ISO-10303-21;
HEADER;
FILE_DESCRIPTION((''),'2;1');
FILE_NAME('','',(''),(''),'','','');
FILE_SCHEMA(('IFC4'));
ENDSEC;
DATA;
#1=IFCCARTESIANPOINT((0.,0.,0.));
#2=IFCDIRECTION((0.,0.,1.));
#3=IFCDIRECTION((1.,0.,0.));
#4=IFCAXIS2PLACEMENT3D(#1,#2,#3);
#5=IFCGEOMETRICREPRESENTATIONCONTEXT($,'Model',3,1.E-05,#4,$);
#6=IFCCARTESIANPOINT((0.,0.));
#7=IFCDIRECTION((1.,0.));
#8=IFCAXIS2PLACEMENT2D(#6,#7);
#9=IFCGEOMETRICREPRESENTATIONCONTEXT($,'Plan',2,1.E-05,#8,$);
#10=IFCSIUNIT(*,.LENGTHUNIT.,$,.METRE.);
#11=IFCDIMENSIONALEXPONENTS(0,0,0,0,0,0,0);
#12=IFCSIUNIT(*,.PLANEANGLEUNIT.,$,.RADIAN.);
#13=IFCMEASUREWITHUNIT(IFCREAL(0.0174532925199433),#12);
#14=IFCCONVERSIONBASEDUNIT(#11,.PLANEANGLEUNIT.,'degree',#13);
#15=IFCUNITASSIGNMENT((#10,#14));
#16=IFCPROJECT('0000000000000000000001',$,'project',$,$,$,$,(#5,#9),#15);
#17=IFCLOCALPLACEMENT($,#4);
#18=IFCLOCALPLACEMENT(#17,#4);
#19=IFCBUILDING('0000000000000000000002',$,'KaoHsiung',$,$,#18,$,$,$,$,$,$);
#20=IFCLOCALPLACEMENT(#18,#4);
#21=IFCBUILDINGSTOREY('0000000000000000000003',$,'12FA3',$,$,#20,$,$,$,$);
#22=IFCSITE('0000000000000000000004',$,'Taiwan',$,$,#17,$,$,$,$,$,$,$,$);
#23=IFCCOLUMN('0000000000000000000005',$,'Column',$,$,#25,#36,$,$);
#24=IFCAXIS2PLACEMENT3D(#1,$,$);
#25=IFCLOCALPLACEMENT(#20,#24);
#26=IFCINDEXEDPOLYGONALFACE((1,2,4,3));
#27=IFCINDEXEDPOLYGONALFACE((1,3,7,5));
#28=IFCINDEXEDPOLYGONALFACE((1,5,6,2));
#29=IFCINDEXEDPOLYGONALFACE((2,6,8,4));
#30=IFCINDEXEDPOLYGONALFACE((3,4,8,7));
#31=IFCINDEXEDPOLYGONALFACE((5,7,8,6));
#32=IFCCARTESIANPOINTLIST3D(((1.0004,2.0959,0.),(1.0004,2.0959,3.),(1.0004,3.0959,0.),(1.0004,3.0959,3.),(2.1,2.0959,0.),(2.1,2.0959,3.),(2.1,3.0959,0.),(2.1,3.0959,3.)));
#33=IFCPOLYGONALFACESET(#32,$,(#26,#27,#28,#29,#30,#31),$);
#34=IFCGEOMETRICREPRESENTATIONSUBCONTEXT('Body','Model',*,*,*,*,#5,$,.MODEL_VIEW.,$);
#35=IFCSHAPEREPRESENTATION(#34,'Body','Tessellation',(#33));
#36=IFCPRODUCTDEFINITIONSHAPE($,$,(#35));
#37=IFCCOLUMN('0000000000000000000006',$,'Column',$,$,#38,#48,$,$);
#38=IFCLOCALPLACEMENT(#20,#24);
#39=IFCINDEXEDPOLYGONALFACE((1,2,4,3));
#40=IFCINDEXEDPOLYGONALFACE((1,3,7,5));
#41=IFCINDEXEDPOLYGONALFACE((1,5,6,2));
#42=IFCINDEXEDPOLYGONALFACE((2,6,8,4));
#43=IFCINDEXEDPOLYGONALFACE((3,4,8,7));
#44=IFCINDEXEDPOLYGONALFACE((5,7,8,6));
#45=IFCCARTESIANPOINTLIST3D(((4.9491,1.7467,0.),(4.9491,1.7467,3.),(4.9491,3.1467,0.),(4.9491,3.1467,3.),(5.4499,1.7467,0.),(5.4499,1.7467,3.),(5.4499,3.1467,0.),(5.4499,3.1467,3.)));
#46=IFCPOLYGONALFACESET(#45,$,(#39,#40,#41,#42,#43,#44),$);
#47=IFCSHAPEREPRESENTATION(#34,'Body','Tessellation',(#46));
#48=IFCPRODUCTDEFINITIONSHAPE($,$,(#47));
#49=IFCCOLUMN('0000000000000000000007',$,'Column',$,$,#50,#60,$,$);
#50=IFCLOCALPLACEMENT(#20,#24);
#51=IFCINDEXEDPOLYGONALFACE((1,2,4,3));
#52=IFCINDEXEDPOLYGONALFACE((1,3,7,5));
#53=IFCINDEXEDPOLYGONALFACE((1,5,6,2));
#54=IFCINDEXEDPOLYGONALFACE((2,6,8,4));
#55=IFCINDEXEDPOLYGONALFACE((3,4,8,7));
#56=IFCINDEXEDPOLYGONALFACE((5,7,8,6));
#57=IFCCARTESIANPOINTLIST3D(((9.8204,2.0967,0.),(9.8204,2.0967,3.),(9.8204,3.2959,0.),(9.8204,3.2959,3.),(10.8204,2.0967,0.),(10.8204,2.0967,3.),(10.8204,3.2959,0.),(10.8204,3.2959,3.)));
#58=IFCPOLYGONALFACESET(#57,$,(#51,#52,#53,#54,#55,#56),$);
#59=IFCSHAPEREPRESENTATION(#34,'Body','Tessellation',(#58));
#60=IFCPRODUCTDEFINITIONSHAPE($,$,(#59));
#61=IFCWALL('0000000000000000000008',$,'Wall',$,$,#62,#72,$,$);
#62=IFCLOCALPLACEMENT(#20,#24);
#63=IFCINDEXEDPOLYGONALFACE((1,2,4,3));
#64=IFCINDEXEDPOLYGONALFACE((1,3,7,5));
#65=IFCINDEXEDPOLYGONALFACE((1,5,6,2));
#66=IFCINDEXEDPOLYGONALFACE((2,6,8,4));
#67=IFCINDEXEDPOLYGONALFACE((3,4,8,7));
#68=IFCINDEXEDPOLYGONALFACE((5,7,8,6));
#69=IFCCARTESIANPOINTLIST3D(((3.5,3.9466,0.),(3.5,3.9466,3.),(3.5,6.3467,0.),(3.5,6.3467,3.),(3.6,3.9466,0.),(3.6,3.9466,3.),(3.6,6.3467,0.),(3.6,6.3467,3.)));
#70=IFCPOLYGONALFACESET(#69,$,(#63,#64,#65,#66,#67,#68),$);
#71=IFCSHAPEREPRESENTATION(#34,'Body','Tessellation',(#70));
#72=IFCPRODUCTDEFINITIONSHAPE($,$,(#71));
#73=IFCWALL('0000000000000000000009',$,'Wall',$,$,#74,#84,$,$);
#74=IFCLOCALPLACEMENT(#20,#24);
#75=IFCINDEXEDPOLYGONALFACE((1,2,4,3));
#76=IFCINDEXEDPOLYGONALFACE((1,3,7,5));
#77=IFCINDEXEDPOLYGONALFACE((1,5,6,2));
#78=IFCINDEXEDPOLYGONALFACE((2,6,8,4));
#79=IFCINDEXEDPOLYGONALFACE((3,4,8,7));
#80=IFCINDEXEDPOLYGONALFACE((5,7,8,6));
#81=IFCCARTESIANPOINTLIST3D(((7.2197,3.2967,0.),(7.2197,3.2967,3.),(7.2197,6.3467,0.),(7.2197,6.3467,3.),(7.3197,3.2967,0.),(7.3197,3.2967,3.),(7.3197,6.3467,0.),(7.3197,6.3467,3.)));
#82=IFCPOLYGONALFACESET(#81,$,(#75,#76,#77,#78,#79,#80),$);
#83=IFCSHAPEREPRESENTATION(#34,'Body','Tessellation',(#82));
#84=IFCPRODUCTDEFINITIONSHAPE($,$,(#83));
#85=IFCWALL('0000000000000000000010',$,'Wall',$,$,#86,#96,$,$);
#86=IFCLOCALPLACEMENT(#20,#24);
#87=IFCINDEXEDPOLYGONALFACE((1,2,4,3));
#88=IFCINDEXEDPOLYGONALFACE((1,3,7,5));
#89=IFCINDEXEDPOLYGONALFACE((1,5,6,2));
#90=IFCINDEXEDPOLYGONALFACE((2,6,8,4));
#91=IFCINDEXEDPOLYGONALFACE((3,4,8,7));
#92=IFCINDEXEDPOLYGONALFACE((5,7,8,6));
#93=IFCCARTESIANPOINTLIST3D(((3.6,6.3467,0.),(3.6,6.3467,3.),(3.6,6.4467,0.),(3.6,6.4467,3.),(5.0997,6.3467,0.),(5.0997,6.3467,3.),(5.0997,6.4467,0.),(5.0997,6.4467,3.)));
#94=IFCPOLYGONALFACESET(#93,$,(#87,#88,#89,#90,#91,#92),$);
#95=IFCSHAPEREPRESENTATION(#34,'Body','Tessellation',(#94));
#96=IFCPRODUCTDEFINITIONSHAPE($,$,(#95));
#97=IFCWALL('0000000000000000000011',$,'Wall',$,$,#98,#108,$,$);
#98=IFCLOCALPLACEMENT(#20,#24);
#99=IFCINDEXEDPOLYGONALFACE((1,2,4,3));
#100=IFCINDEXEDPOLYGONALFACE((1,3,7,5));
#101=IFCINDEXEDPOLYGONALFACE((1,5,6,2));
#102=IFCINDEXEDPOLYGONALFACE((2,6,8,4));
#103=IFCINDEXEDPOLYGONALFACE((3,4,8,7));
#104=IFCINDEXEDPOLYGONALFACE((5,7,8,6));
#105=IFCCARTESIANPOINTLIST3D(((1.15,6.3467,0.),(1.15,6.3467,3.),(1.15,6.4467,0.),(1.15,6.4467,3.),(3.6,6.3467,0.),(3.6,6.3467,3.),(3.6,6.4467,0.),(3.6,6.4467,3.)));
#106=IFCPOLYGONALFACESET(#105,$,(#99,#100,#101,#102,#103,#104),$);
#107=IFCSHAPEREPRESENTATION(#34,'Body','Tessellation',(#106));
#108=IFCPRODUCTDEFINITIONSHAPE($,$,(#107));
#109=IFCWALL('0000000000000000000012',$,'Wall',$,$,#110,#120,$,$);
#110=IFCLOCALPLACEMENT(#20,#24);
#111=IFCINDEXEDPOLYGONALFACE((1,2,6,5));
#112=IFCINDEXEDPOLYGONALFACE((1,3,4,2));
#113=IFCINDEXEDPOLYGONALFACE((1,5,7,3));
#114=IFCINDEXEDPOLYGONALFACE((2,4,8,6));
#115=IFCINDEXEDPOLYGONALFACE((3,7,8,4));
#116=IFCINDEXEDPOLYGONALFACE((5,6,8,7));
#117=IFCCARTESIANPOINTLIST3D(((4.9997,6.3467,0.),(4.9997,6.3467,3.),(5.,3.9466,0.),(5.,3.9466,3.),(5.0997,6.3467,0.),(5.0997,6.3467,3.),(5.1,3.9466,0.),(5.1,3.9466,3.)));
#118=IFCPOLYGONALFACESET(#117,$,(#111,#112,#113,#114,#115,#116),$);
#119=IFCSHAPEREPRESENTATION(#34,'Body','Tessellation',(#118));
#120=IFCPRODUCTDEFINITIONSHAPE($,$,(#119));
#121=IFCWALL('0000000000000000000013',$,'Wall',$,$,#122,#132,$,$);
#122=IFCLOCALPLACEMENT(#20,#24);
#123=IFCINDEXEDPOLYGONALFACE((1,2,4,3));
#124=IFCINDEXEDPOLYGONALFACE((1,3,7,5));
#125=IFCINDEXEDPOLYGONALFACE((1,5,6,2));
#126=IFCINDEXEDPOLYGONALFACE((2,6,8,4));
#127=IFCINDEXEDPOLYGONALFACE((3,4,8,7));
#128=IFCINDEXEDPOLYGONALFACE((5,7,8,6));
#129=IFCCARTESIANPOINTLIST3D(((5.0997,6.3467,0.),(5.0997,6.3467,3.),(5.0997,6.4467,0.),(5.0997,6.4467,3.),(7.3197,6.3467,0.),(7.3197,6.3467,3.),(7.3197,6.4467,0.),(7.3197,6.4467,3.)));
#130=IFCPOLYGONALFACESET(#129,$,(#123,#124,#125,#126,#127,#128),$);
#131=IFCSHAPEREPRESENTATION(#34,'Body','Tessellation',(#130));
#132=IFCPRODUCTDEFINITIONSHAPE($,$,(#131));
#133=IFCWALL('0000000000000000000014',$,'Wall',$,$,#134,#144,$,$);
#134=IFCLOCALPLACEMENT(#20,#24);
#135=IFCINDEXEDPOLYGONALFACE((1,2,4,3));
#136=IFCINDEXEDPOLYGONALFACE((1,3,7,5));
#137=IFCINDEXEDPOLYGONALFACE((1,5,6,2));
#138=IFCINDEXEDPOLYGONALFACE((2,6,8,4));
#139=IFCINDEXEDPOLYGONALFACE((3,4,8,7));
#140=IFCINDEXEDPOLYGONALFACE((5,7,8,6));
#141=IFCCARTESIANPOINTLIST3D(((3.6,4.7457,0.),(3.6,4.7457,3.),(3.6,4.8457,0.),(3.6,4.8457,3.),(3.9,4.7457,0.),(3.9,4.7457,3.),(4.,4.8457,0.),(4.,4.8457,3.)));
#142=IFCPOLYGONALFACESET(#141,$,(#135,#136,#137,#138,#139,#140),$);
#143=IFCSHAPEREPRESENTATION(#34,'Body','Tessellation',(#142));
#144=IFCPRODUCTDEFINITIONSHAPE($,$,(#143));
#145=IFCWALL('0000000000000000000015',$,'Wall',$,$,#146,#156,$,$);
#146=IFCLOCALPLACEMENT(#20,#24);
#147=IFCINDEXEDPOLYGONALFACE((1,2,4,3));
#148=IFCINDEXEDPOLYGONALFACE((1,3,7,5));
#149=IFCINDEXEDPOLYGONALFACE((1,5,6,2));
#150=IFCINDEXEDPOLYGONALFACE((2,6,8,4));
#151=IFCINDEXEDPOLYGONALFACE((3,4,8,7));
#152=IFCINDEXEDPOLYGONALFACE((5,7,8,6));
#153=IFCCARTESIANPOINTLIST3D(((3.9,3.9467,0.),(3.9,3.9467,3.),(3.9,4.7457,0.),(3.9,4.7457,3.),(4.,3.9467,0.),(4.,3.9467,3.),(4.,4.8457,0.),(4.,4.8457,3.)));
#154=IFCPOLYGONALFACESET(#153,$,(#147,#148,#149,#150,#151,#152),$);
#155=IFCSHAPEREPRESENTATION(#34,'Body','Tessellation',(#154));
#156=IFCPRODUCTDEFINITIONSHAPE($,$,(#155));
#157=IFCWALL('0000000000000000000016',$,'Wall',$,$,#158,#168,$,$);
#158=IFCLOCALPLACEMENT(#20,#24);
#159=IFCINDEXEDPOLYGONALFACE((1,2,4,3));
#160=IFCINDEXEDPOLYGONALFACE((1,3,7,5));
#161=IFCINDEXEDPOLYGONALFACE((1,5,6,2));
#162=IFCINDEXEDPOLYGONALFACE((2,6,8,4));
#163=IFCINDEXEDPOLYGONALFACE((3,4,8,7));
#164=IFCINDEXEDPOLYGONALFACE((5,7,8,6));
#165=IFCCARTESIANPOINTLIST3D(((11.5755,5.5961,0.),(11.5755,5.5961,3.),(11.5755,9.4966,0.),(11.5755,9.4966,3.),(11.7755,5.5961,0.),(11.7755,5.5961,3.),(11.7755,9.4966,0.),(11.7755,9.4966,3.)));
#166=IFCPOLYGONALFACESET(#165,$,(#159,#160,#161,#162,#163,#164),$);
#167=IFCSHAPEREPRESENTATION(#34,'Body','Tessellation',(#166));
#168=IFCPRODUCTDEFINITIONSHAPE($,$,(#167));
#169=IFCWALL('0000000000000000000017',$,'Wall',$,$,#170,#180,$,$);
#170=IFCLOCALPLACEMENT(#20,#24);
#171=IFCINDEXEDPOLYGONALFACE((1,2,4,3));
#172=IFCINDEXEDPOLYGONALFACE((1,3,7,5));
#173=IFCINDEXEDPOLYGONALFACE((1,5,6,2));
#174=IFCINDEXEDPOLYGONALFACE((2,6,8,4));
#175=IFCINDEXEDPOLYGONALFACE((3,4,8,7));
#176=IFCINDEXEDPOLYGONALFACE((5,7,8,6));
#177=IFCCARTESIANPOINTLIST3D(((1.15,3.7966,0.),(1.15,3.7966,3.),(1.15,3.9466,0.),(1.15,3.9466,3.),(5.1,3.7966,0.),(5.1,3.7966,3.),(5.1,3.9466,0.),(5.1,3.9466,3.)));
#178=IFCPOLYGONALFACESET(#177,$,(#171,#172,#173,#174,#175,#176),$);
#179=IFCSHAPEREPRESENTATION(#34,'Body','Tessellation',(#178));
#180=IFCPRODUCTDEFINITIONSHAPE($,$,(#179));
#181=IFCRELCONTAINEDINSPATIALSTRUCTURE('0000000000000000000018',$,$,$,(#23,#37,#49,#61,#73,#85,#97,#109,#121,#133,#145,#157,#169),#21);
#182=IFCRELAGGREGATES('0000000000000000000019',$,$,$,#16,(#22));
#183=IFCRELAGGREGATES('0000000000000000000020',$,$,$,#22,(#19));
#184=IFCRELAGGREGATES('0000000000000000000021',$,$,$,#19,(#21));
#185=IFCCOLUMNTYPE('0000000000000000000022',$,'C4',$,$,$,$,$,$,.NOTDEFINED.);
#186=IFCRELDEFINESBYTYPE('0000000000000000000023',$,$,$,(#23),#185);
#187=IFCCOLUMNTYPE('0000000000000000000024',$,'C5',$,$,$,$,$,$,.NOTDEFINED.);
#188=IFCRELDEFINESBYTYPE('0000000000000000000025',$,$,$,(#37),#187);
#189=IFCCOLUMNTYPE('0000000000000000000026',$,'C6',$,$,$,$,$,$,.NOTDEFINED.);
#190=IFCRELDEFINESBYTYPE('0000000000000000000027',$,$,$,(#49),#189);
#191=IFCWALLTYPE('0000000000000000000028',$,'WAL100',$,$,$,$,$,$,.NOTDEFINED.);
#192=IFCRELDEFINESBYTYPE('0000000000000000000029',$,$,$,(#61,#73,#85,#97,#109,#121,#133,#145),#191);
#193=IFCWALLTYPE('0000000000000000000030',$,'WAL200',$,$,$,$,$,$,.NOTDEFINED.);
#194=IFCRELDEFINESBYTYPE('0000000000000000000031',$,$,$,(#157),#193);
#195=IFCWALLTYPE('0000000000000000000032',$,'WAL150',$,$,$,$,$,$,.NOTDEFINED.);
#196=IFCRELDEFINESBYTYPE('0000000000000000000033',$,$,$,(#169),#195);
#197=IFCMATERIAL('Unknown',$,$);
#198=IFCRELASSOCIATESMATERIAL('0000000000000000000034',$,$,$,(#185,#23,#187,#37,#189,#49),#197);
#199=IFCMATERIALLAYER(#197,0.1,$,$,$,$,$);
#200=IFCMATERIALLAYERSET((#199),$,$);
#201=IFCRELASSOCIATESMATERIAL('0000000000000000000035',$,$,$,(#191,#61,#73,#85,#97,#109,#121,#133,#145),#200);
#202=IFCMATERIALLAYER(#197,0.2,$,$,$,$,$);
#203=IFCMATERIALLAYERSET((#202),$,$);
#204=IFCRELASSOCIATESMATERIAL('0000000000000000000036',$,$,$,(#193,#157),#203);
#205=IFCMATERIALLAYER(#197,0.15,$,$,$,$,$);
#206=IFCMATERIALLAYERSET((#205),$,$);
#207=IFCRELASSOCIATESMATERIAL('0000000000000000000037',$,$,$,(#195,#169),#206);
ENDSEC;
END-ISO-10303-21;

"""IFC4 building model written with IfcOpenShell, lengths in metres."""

from ifc_helpers import new_model, entity, si_unit, converted_unit, frame, origin_with_axes, origin_2d_with_axis, place, context, subcontext, project, spatial, line, indexed_curve, outline, extrude, material, layer, layer_set, layer_usage, material_profile, profile_set, profile_usage, type_object, element, save


model = new_model("IFC4")

# Units and contexts
model_context = context("Model", 3, precision=1e-05, world=origin_with_axes())
plan_context = context("Plan", 2, precision=1e-05, world=origin_2d_with_axis())
body_context = subcontext(model_context, "Body", "Model", "MODEL_VIEW")
ifc_project = project(units=[si_unit("LENGTHUNIT", "METRE"), converted_unit("PLANEANGLEUNIT", "degree", entity("IfcReal", 0.0174532925199433), si_unit("PLANEANGLEUNIT", "RADIAN"), dimensions=[0, 0, 0, 0, 0, 0, 0])], contexts=[model_context, plan_context])

# Site, building, storey
site_placement = place(None, origin_with_axes())
site = spatial("IfcSite", under=ifc_project, at=site_placement, Name="Taiwan")
building_placement = place(site_placement, origin_with_axes())
building = spatial("IfcBuilding", under=site, at=building_placement, Name="KaoHsiung")
storey_placement = place(building_placement, origin_with_axes())
storey = spatial("IfcBuildingStorey", under=building, at=storey_placement, Name="12FA3")

# Columns
ifc_material = material(Name="Unknown")
ifc_material_profile_1 = material_profile(ifc_material, outline(indexed_curve([(0.0, 1.0), (1.0995, 1.0), (1.0995, 0.0), (0.0, 0.0), (0.0, 1.0)])))
ifc_profile_set_1 = profile_set([ifc_material_profile_1])
ifc_profile_usage_1 = profile_usage(ifc_profile_set_1, cardinal=5)
column_type_1 = type_object("IfcColumnType", Name="C4", PredefinedType="NOTDEFINED", material=ifc_profile_set_1)
column_1_placement = place(storey_placement, frame((1.0004, 2.0959, 0.0), z_axis=(0.0, 0.0, 1.0), x_axis=(1.0, 0.0, 0.0)))
element("IfcColumn", 1, at=column_1_placement, inside=storey, type_object=column_type_1, material=ifc_profile_usage_1, Name="Column", context=body_context, shape_type="SweptSolid", body=[
    extrude(outline(indexed_curve([(0.0, 1.0), (1.0995, 1.0), (1.0995, 0.0), (0.0, 0.0), (0.0, 1.0)])), origin_with_axes(), (0.0, 0.0, 1.0), 3.0),
])
ifc_material_profile_2 = material_profile(ifc_material, outline(indexed_curve([(0.0, 0.0), (0.5008, 0.0), (0.5008, 1.4), (0.0, 1.4), (0.0, 0.0)])))
ifc_profile_set_2 = profile_set([ifc_material_profile_2])
ifc_profile_usage_2 = profile_usage(ifc_profile_set_2, cardinal=5)
column_type_2 = type_object("IfcColumnType", Name="C5", PredefinedType="NOTDEFINED", material=ifc_profile_set_2)
column_2_placement = place(storey_placement, frame((4.9491, 1.7467, 0.0), z_axis=(0.0, 0.0, 1.0), x_axis=(1.0, 0.0, 0.0)))
element("IfcColumn", 2, at=column_2_placement, inside=storey, type_object=column_type_2, material=ifc_profile_usage_2, Name="Column", context=body_context, shape_type="SweptSolid", body=[
    extrude(outline(indexed_curve([(0.0, 0.0), (0.5008, 0.0), (0.5008, 1.4), (0.0, 1.4), (0.0, 0.0)])), origin_with_axes(), (0.0, 0.0, 1.0), 3.0),
])
ifc_material_profile_3 = material_profile(ifc_material, outline(indexed_curve([(0.0, 1.1992), (1.0, 1.1992), (1.0, 0.0), (0.0, 0.0), (0.0, 1.1992)])))
ifc_profile_set_3 = profile_set([ifc_material_profile_3])
ifc_profile_usage_3 = profile_usage(ifc_profile_set_3, cardinal=5)
column_type_3 = type_object("IfcColumnType", Name="C6", PredefinedType="NOTDEFINED", material=ifc_profile_set_3)
column_3_placement = place(storey_placement, frame((9.8204, 2.0967, 0.0), z_axis=(0.0, 0.0, 1.0), x_axis=(1.0, 0.0, 0.0)))
element("IfcColumn", 3, at=column_3_placement, inside=storey, type_object=column_type_3, material=ifc_profile_usage_3, Name="Column", context=body_context, shape_type="SweptSolid", body=[
    extrude(outline(indexed_curve([(0.0, 1.1992), (1.0, 1.1992), (1.0, 0.0), (0.0, 0.0), (0.0, 1.1992)])), origin_with_axes(), (0.0, 0.0, 1.0), 3.0),
])

# Walls
ifc_layer_1 = layer(ifc_material, 0.1)
ifc_layer_set_1 = layer_set([ifc_layer_1])
ifc_layer_usage_1 = layer_usage(ifc_layer_set_1, "AXIS2", "POSITIVE", 0.0)
wall_type_1 = type_object("IfcWallType", Name="WAL100", PredefinedType="NOTDEFINED", material=ifc_layer_set_1)
wall_1_placement = place(storey_placement, frame((3.6, 3.9466, 0.0), z_axis=(0.0, 0.0, 1.0), x_axis=(0.0, 1.0, 0.0)))
element("IfcWall", 4, at=wall_1_placement, inside=storey, type_object=wall_type_1, material=ifc_layer_usage_1, Name="Wall", context=body_context, shape_type="SweptSolid", body=[
    extrude(outline(indexed_curve([(0.0, 0.0), (0.0, 0.1), (2.4001, 0.1), (2.4001, 0.0)], segments=[line(1, 2, 3, 4, 1)])), origin_with_axes(), (0.0, 0.0, 1.0), 3.0),
])
ifc_layer_usage_2 = layer_usage(ifc_layer_set_1, "AXIS2", "POSITIVE", 0.0)
wall_2_placement = place(storey_placement, frame((7.3197, 3.2967, 0.0), z_axis=(0.0, 0.0, 1.0), x_axis=(0.0, 1.0, 0.0)))
element("IfcWall", 5, at=wall_2_placement, inside=storey, type_object=wall_type_1, material=ifc_layer_usage_2, Name="Wall", context=body_context, shape_type="SweptSolid", body=[
    extrude(outline(indexed_curve([(0.0, 0.0), (0.0, 0.1), (3.05, 0.1), (3.05, 0.0)], segments=[line(1, 2, 3, 4, 1)])), origin_with_axes(), (0.0, 0.0, 1.0), 3.0),
])
ifc_layer_usage_3 = layer_usage(ifc_layer_set_1, "AXIS2", "POSITIVE", 0.0)
wall_3_placement = place(storey_placement, frame((5.0997, 6.4467, 0.0), z_axis=(0.0, 0.0, 1.0), x_axis=(-1.0, 0.0, 0.0)))
element("IfcWall", 6, at=wall_3_placement, inside=storey, type_object=wall_type_1, material=ifc_layer_usage_3, Name="Wall", context=body_context, shape_type="SweptSolid", body=[
    extrude(outline(indexed_curve([(0.0, 0.0), (0.0, 0.1), (1.4997, 0.1), (1.4997, 0.0)], segments=[line(1, 2, 3, 4, 1)])), origin_with_axes(), (0.0, 0.0, 1.0), 3.0),
])
ifc_layer_usage_4 = layer_usage(ifc_layer_set_1, "AXIS2", "POSITIVE", 0.0)
wall_4_placement = place(storey_placement, frame((3.6, 6.4467, 0.0), z_axis=(0.0, 0.0, 1.0), x_axis=(-1.0, 0.0, 0.0)))
element("IfcWall", 7, at=wall_4_placement, inside=storey, type_object=wall_type_1, material=ifc_layer_usage_4, Name="Wall", context=body_context, shape_type="SweptSolid", body=[
    extrude(outline(indexed_curve([(0.0, 0.0), (0.0, 0.1), (2.45, 0.1), (2.45, 0.0)], segments=[line(1, 2, 3, 4, 1)])), origin_with_axes(), (0.0, 0.0, 1.0), 3.0),
])
ifc_layer_usage_5 = layer_usage(ifc_layer_set_1, "AXIS2", "POSITIVE", 0.0)
wall_5_placement = place(storey_placement, frame((4.9997, 6.3467, 0.0), z_axis=(0.0, 0.0, 1.0), x_axis=(0.000135, -1.0, 0.0)))
element("IfcWall", 8, at=wall_5_placement, inside=storey, type_object=wall_type_1, material=ifc_layer_usage_5, Name="Wall", context=body_context, shape_type="SweptSolid", body=[
    extrude(outline(indexed_curve([(0.0, 0.0), (0.0, 0.1), (2.4001, 0.1), (2.4001, 0.0)], segments=[line(1, 2, 3, 4, 1)])), origin_with_axes(), (0.0, 0.0, 1.0), 3.0),
])
ifc_layer_usage_6 = layer_usage(ifc_layer_set_1, "AXIS2", "POSITIVE", 0.0)
wall_6_placement = place(storey_placement, frame((7.3197, 6.4467, 0.0), z_axis=(0.0, 0.0, 1.0), x_axis=(-1.0, 0.0, 0.0)))
element("IfcWall", 9, at=wall_6_placement, inside=storey, type_object=wall_type_1, material=ifc_layer_usage_6, Name="Wall", context=body_context, shape_type="SweptSolid", body=[
    extrude(outline(indexed_curve([(0.0, 0.0), (0.0, 0.1), (2.22, 0.1), (2.22, 0.0)], segments=[line(1, 2, 3, 4, 1)])), origin_with_axes(), (0.0, 0.0, 1.0), 3.0),
])
ifc_layer_usage_7 = layer_usage(ifc_layer_set_1, "AXIS2", "POSITIVE", 0.0)
wall_7_placement = place(storey_placement, frame((3.6, 4.7457, 0.0), z_axis=(0.0, 0.0, 1.0), x_axis=(1.0, 0.0, 0.0)))
element("IfcWall", 10, at=wall_7_placement, inside=storey, type_object=wall_type_1, material=ifc_layer_usage_7, Name="Wall", context=body_context, shape_type="SweptSolid", body=[
    extrude(outline(indexed_curve([(0.0, 0.0), (0.0, 0.1), (0.4, 0.1), (0.3, 0.0)], segments=[line(1, 2, 3, 4, 1)])), origin_with_axes(), (0.0, 0.0, 1.0), 3.0),
])
ifc_layer_usage_8 = layer_usage(ifc_layer_set_1, "AXIS2", "POSITIVE", 0.0)
wall_8_placement = place(storey_placement, frame((3.9, 4.7457, 0.0), z_axis=(0.0, 0.0, 1.0), x_axis=(0.0, -1.0, 0.0)))
element("IfcWall", 11, at=wall_8_placement, inside=storey, type_object=wall_type_1, material=ifc_layer_usage_8, Name="Wall", context=body_context, shape_type="SweptSolid", body=[
    extrude(outline(indexed_curve([(0.0, 0.0), (-0.1, 0.1), (0.799, 0.1), (0.799, 0.0)], segments=[line(1, 2, 3, 4, 1)])), origin_with_axes(), (0.0, 0.0, 1.0), 3.0),
])
ifc_layer_2 = layer(ifc_material, 0.2)
ifc_layer_set_2 = layer_set([ifc_layer_2])
ifc_layer_usage_9 = layer_usage(ifc_layer_set_2, "AXIS2", "POSITIVE", 0.0)
wall_type_2 = type_object("IfcWallType", Name="WAL200", PredefinedType="NOTDEFINED", material=ifc_layer_set_2)
wall_9_placement = place(storey_placement, frame((11.7755, 5.5961, 0.0), z_axis=(0.0, 0.0, 1.0), x_axis=(0.0, 1.0, 0.0)))
element("IfcWall", 12, at=wall_9_placement, inside=storey, type_object=wall_type_2, material=ifc_layer_usage_9, Name="Wall", context=body_context, shape_type="SweptSolid", body=[
    extrude(outline(indexed_curve([(0.0, 0.0), (0.0, 0.2), (3.9005, 0.2), (3.9005, 0.0)], segments=[line(1, 2, 3, 4, 1)])), origin_with_axes(), (0.0, 0.0, 1.0), 3.0),
])
ifc_layer_3 = layer(ifc_material, 0.15)
ifc_layer_set_3 = layer_set([ifc_layer_3])
ifc_layer_usage_10 = layer_usage(ifc_layer_set_3, "AXIS2", "POSITIVE", 0.0)
wall_type_3 = type_object("IfcWallType", Name="WAL150", PredefinedType="NOTDEFINED", material=ifc_layer_set_3)
wall_10_placement = place(storey_placement, frame((1.15, 3.7966, 0.0), z_axis=(0.0, 0.0, 1.0), x_axis=(1.0, 0.0, 0.0)))
element("IfcWall", 13, at=wall_10_placement, inside=storey, type_object=wall_type_3, material=ifc_layer_usage_10, Name="Wall", context=body_context, shape_type="SweptSolid", body=[
    extrude(outline(indexed_curve([(0.0, 0.0), (0.0, 0.15), (3.95, 0.15), (3.95, 0.0)], segments=[line(1, 2, 3, 4, 1)])), origin_with_axes(), (0.0, 0.0, 1.0), 3.0),
])

save(model, "model.ifc")
